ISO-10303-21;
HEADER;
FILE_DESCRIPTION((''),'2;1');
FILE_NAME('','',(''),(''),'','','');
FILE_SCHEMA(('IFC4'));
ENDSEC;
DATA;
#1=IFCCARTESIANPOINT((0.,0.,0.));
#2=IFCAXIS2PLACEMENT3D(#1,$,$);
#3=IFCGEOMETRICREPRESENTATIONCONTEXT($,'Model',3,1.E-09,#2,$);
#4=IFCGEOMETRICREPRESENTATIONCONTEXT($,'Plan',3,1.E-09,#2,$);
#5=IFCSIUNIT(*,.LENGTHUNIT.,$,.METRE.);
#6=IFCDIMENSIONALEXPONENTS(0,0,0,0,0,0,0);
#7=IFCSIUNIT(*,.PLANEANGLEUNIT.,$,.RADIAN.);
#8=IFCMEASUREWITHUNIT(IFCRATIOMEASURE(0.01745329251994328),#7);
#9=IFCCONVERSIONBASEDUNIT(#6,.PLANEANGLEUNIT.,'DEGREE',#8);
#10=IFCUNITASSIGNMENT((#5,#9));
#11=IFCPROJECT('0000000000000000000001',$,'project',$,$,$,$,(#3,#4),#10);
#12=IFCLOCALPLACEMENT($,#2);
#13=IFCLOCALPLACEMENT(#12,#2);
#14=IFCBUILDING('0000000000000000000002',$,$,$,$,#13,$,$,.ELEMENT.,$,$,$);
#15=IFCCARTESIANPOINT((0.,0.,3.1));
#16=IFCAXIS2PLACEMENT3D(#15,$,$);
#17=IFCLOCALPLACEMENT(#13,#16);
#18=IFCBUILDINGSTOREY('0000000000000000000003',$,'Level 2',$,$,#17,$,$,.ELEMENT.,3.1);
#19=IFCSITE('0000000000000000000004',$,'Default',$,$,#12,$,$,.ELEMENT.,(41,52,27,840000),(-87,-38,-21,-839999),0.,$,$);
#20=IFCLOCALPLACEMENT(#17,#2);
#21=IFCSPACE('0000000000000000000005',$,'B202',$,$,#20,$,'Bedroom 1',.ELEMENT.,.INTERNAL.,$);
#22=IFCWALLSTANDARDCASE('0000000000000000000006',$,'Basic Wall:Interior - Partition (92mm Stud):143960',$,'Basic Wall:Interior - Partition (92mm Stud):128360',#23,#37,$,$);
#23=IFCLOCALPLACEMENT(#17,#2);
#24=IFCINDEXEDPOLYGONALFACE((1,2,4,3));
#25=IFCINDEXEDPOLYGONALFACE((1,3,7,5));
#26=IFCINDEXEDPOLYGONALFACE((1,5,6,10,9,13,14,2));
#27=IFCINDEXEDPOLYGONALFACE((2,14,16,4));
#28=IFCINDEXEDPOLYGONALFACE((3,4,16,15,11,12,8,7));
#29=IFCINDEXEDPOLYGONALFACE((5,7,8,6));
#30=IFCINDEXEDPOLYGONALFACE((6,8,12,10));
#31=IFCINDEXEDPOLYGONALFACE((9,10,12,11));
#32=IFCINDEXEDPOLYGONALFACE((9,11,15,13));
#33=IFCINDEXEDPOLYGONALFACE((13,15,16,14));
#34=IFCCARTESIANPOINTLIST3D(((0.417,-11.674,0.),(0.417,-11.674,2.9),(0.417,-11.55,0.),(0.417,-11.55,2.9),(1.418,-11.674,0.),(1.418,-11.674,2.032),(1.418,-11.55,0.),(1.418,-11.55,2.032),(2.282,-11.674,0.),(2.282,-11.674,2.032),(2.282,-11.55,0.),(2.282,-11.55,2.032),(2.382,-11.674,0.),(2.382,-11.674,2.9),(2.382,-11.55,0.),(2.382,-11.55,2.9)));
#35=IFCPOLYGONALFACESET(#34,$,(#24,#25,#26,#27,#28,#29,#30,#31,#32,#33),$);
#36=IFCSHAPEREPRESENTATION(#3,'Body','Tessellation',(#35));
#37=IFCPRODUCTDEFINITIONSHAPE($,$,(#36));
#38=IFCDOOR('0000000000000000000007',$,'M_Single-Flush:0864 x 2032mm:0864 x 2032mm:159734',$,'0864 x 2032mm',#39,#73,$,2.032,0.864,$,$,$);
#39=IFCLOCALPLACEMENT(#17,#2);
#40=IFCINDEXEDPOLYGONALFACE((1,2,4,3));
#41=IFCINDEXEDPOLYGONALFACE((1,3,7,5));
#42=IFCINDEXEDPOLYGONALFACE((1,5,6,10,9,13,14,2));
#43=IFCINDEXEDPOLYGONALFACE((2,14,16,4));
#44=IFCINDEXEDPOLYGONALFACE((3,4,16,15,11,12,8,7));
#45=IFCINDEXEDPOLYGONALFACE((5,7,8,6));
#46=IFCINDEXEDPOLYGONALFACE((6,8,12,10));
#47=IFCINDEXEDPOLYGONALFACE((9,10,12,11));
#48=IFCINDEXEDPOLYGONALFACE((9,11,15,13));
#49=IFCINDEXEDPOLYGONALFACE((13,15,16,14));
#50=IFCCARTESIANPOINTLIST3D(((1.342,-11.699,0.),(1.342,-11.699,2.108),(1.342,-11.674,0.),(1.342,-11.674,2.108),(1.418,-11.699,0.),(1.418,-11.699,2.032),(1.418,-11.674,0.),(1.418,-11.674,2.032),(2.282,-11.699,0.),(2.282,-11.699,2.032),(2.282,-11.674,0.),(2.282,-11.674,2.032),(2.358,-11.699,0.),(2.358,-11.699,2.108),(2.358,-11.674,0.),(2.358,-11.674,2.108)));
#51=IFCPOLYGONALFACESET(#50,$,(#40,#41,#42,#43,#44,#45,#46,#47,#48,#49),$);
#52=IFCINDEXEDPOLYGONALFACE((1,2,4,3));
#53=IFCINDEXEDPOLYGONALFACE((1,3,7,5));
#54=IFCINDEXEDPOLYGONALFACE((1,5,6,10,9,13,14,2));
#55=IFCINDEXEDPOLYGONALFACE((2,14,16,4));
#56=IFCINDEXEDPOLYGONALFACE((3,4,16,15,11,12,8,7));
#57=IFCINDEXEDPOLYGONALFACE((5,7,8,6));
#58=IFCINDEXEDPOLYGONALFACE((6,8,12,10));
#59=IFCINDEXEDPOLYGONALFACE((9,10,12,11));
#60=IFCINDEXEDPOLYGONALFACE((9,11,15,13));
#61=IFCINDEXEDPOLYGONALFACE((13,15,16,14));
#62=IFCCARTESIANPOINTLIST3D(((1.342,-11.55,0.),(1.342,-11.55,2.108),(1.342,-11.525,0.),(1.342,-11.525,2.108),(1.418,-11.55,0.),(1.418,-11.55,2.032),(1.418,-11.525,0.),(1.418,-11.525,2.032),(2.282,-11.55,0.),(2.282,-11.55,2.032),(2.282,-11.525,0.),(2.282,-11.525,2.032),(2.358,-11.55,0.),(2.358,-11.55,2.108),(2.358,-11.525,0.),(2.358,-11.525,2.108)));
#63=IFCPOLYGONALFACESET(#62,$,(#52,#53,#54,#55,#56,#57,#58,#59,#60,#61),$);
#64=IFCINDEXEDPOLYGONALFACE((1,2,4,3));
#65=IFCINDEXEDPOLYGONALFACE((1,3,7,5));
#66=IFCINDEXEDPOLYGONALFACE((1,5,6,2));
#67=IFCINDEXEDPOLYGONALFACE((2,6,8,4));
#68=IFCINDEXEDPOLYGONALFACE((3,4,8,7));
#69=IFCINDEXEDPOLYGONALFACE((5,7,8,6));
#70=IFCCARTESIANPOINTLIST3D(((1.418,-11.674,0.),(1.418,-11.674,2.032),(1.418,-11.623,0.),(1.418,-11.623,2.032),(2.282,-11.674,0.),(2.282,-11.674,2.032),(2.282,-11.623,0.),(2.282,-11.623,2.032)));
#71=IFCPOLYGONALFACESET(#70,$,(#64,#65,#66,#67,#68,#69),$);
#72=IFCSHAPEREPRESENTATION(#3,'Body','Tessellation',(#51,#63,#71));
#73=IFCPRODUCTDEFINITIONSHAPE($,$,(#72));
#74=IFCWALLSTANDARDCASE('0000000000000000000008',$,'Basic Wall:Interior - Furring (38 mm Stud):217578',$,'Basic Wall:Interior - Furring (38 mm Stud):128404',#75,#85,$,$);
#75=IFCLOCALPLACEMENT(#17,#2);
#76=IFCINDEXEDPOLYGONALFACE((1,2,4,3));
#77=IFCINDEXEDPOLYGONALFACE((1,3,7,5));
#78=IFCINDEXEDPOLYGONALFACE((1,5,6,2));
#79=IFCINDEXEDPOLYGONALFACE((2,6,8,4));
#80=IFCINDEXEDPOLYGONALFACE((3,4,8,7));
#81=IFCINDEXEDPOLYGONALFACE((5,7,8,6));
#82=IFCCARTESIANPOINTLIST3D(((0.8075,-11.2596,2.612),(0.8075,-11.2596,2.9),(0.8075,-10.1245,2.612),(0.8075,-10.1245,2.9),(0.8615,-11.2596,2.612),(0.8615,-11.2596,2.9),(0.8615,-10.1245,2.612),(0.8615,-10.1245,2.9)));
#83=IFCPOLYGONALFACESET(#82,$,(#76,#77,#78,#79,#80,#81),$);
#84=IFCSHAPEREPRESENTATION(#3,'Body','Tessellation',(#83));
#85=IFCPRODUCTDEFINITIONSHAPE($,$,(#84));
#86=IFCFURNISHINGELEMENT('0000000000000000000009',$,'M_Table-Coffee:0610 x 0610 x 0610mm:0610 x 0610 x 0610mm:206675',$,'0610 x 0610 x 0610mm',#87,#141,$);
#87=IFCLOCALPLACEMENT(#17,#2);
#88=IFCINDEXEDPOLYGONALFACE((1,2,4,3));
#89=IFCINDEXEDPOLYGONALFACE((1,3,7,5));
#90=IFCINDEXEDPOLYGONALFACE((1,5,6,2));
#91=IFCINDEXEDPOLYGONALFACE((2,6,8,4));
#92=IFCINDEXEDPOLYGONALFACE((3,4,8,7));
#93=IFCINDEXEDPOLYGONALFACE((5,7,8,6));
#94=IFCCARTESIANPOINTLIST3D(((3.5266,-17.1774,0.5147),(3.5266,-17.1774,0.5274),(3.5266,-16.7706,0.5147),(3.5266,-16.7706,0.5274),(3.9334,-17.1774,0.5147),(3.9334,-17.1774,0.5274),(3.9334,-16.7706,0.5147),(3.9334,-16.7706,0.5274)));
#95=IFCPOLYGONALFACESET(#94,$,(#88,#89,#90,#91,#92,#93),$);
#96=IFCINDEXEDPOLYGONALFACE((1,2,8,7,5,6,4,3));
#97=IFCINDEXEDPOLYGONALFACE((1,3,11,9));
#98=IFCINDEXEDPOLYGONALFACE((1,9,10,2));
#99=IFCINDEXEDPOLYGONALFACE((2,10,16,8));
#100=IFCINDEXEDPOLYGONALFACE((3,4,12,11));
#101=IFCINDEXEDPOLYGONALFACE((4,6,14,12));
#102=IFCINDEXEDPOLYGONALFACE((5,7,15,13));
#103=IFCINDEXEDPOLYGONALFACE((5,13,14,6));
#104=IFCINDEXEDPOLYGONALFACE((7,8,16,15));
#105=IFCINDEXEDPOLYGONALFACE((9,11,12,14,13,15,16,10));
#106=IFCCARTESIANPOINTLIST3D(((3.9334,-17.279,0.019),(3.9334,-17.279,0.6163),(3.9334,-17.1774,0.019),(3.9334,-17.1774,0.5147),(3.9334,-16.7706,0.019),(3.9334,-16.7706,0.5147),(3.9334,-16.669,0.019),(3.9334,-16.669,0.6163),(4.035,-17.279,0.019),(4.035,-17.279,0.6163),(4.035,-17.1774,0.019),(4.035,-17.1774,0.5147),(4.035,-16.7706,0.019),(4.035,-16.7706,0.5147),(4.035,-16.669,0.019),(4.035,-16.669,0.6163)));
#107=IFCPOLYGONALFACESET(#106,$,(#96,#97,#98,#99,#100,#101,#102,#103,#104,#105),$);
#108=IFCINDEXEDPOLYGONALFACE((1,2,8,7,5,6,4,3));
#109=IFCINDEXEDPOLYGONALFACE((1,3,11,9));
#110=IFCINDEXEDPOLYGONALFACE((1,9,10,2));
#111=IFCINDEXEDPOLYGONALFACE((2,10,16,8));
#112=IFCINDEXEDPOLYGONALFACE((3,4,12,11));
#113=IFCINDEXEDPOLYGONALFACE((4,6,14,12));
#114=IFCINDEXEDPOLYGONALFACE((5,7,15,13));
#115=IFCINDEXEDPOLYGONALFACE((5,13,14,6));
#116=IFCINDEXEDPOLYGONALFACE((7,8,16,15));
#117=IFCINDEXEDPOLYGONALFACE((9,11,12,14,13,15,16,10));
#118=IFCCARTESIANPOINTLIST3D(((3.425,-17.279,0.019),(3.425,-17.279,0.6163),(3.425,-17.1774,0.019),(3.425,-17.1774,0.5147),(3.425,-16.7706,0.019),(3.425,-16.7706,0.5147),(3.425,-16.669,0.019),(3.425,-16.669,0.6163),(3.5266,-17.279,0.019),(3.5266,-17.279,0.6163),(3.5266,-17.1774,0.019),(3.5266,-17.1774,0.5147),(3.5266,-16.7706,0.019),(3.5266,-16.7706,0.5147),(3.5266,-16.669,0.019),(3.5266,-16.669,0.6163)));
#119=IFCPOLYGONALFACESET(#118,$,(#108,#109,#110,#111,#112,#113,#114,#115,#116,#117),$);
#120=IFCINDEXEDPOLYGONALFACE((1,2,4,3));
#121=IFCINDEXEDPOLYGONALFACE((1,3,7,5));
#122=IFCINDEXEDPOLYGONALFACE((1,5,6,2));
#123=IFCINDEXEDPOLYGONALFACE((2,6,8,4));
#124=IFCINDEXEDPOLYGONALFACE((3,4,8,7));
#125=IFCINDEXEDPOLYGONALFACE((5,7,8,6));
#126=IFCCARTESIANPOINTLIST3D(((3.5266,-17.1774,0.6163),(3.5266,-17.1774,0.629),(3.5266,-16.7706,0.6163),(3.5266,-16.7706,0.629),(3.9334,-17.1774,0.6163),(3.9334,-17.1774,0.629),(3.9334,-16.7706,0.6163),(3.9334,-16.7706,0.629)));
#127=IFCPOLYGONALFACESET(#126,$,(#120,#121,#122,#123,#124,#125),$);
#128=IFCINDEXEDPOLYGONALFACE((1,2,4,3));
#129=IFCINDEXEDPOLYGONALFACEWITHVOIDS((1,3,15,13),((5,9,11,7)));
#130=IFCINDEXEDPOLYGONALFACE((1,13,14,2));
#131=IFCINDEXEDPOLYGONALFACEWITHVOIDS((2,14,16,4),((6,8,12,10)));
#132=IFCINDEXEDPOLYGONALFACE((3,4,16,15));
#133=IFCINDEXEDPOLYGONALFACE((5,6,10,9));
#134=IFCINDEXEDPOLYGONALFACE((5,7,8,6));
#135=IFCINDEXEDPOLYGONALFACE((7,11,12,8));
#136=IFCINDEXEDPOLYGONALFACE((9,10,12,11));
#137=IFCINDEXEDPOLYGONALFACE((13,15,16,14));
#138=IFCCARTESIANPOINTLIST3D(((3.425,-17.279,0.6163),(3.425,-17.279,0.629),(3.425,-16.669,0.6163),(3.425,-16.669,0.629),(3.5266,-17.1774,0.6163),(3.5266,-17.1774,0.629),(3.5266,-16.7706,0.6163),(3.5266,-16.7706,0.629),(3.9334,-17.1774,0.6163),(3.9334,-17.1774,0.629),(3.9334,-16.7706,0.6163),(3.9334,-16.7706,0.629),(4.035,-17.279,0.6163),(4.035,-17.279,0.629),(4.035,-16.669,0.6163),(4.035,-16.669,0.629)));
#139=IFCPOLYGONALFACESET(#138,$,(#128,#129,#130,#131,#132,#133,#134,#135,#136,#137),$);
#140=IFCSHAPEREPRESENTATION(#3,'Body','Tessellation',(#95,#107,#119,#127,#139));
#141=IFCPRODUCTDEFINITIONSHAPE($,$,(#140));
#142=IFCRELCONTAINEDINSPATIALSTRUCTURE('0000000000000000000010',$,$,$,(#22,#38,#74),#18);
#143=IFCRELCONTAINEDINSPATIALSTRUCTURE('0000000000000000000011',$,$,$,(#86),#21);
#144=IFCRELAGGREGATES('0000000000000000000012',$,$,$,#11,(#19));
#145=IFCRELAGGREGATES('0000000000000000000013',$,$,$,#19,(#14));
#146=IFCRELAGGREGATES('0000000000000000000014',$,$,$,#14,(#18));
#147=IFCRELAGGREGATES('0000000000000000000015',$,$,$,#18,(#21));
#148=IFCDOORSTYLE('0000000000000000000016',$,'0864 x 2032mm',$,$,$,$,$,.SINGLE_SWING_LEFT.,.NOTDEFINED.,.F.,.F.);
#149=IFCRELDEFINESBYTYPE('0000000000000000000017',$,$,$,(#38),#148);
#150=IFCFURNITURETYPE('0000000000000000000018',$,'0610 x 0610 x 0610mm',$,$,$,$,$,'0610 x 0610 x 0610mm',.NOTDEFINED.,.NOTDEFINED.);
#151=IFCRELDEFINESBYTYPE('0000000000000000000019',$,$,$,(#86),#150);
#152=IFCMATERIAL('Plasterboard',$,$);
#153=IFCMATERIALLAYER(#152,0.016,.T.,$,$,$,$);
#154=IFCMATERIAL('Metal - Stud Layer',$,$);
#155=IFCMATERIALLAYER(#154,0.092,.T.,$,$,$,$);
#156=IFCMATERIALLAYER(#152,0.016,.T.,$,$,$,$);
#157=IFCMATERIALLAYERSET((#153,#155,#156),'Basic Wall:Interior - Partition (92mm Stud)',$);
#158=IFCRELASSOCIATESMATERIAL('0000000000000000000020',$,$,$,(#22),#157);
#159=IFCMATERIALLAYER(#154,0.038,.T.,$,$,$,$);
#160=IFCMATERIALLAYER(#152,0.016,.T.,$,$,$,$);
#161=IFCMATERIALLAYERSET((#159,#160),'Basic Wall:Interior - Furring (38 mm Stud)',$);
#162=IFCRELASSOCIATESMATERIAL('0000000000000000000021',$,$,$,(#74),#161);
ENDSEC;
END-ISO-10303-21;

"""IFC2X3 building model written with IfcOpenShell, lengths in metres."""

from ifc_helpers import new_model, entity, si_unit, converted_unit, frame, frame_2d, origin, origin_2d_with_axis, place, context, project, spatial, polyline, rectangle, outline, extrude, source, transform, mapped, material, layer, layer_set, layer_usage, type_object, type_shapes, element, fill, save


model = new_model("IFC2X3")

# Units and contexts
model_context = context("Model", 3, precision=1e-09, world=origin())
plan_context = context("Plan", 3, precision=1e-09, world=origin())
ifc_project = project(units=[si_unit("LENGTHUNIT", "METRE"), converted_unit("PLANEANGLEUNIT", "DEGREE", entity("IfcRatioMeasure", 0.01745329251994328), si_unit("PLANEANGLEUNIT", "RADIAN"), dimensions=[0, 0, 0, 0, 0, 0, 0])], contexts=[model_context, plan_context])

# Site, building, storey
site_placement = place(None, origin())
site = spatial("IfcSite", under=ifc_project, at=site_placement, Name="Default", CompositionType="ELEMENT", RefLatitude=(41, 52, 27, 840000), RefLongitude=(-87, -38, -21, -839999), RefElevation=0.0)
building_placement = place(site_placement, origin())
building = spatial("IfcBuilding", under=site, at=building_placement, CompositionType="ELEMENT")
storey_placement = place(building_placement, frame((0.0, 0.0, 3.1)))
storey = spatial("IfcBuildingStorey", under=building, at=storey_placement, Name="Level 2", CompositionType="ELEMENT", Elevation=3.1)

# Shared definitions
ifc_material_1 = material(Name="Metal - Stud Layer")
ifc_layer_1 = layer(ifc_material_1, 0.038, ventilated=True)
ifc_material_2 = material(Name="Plasterboard")
ifc_layer_2 = layer(ifc_material_2, 0.016, ventilated=True)
ifc_layer_set_1 = layer_set([ifc_layer_1, ifc_layer_2], Name="Basic Wall:Interior - Furring (38 mm Stud)")
ifc_layer_usage_1 = layer_usage(ifc_layer_set_1, "AXIS2", "NEGATIVE", 0.027)

# Wall, opening, door
ifc_layer_3 = layer(ifc_material_2, 0.016, ventilated=True)
ifc_layer_4 = layer(ifc_material_1, 0.092, ventilated=True)
ifc_layer_5 = layer(ifc_material_2, 0.016, ventilated=True)
ifc_layer_set_2 = layer_set([ifc_layer_3, ifc_layer_4, ifc_layer_5], Name="Basic Wall:Interior - Partition (92mm Stud)")
ifc_layer_usage_2 = layer_usage(ifc_layer_set_2, "AXIS2", "NEGATIVE", 0.062)
wall_1_placement = place(storey_placement, frame((2.382, -11.612, 0.0), z_axis=(0.0, 0.0, 1.0), x_axis=(-1.0, 0.0, 0.0)))
wall_1 = element("IfcWallStandardCase", 1, at=wall_1_placement, inside=storey, material=ifc_layer_usage_2, Name="Basic Wall:Interior - Partition (92mm Stud):143960", ObjectType="Basic Wall:Interior - Partition (92mm Stud):128360", context=model_context, shape_type="SweptSolid", body=[
    extrude(rectangle(XDim=1.965, YDim=0.124, at=frame_2d((0.9825, 0.0), x_axis=(-1.0, 0.0))), origin(), (0.0, 0.0, 1.0), 2.9),
])
opening_1_placement = place(wall_1_placement, frame((0.1, -0.062, 0.0)))
opening_1 = element("IfcOpeningElement", 2, at=opening_1_placement, cuts=wall_1, ObjectType="Opening", context=model_context, shape_type="SweptSolid", body=[
    extrude(rectangle(XDim=0.864, YDim=2.032, at=frame_2d((1.016, 0.432), x_axis=(0.0, -1.0))), frame((0.0, 0.0, 0.0), z_axis=(0.0, 1.0, 0.0), x_axis=(0.0, 0.0, 1.0)), (0.0, 0.0, 1.0), 0.124),
])
door_style = type_object("IfcDoorStyle", Name="0864 x 2032mm", ConstructionType="NOTDEFINED", OperationType="SINGLE_SWING_LEFT", ParameterTakesPrecedence=False, Sizeable=False)
shared_shape_1 = source(origin(), model_context, "Body", "SweptSolid", [
    extrude(outline(polyline([(-0.508, -1.073), (0.508, -1.073), (0.508, 1.035), (0.432, 1.035), (0.432, -0.997), (-0.432, -0.997), (-0.432, 1.035), (-0.508, 1.035), (-0.508, -1.073)])), frame((0.432, 0.149, 1.035), z_axis=(0.0, -1.0, 0.0), x_axis=(-1.0, 0.0, 0.0)), (0.0, 0.0, 1.0), 0.025),
    extrude(outline(polyline([(-1.073, -0.508), (1.035, -0.508), (1.035, -0.432), (-0.997, -0.432), (-0.997, 0.432), (1.035, 0.432), (1.035, 0.508), (-1.073, 0.508), (-1.073, -0.508)])), frame((0.432, 0.0, 1.035), z_axis=(0.0, -1.0, 0.0), x_axis=(0.0, 0.0, -1.0)), (0.0, 0.0, 1.0), 0.025),
    extrude(rectangle(XDim=0.864, YDim=0.051, at=origin_2d_with_axis()), frame((0.432, 0.0985, 0.0)), (0.0, 0.0, 1.0), 2.032),
])
type_shapes(door_style, [shared_shape_1])
door_placement = place(opening_1_placement, origin())
door = element("IfcDoor", 3, at=door_placement, inside=storey, type_object=door_style, Name="M_Single-Flush:0864 x 2032mm:0864 x 2032mm:159734", ObjectType="0864 x 2032mm", OverallHeight=2.032, OverallWidth=0.864, context=model_context, shape_type="MappedRepresentation", body=[
    mapped(shared_shape_1, transform((0.0, 0.0, 0.0), scale=1.0)),
])
fill(opening_1, door)

# Wall
wall_2_placement = place(storey_placement, frame((0.8345, -11.2596, 2.612), z_axis=(0.0, 0.0, 1.0), x_axis=(0.0, 1.0, 0.0)))
element("IfcWallStandardCase", 4, at=wall_2_placement, inside=storey, material=ifc_layer_usage_1, Name="Basic Wall:Interior - Furring (38 mm Stud):217578", ObjectType="Basic Wall:Interior - Furring (38 mm Stud):128404", context=model_context, shape_type="SweptSolid", body=[
    extrude(rectangle(XDim=1.1351, YDim=0.054, at=frame_2d((0.5675, 0.0), x_axis=(-1.0, 0.0))), origin(), (0.0, 0.0, 1.0), 0.288),
])

# Shared definitions
space_placement = place(storey_placement, origin())
space = spatial("IfcSpace", under=storey, at=space_placement, Name="B202", LongName="Bedroom 1", CompositionType="ELEMENT", InteriorOrExteriorSpace="INTERNAL")

# Furnishing element
furniture_type = type_object("IfcFurnitureType", Name="0610 x 0610 x 0610mm", ElementType="0610 x 0610 x 0610mm", AssemblyPlace="NOTDEFINED")
shared_shape_2 = source(origin(), model_context, "Body", "SweptSolid", [
    extrude(rectangle(XDim=0.4068, YDim=0.4068, at=origin_2d_with_axis()), frame((0.0183, 0.0952, 0.4957), z_axis=(0.0, 0.0, 1.0), x_axis=(-1.0, 0.0, 0.0)), (0.0, 0.0, 1.0), 0.0127),
    extrude(outline(polyline([(-0.2732, -0.305), (0.324, -0.305), (0.324, 0.305), (-0.2732, 0.305), (-0.2732, 0.2034), (0.2225, 0.2034), (0.2225, -0.2034), (-0.2732, -0.2034), (-0.2732, -0.305)])), frame((0.2217, 0.0952, 0.2732), z_axis=(1.0, 0.0, 0.0), x_axis=(0.0, 0.0, 1.0)), (0.0, 0.0, 1.0), 0.1016),
    extrude(outline(polyline([(-0.305, -0.3241), (0.305, -0.3241), (0.305, 0.2733), (0.2034, 0.2733), (0.2034, -0.2224), (-0.2034, -0.2224), (-0.2034, 0.2733), (-0.305, 0.2733), (-0.305, -0.3241)])), frame((-0.2867, 0.0952, 0.2733), z_axis=(1.0, 0.0, 0.0), x_axis=(0.0, -1.0, 0.0)), (0.0, 0.0, 1.0), 0.1016),
    extrude(rectangle(XDim=0.4068, YDim=0.4068, at=origin_2d_with_axis()), frame((0.0183, 0.0952, 0.5973), z_axis=(0.0, 0.0, 1.0), x_axis=(-1.0, 0.0, 0.0)), (0.0, 0.0, 1.0), 0.0127),
    extrude(outline(polyline([(-0.305, -0.305), (0.305, -0.305), (0.305, 0.305), (-0.305, 0.305), (-0.305, -0.305)]), holes=[polyline([(-0.2034, -0.2034), (-0.2034, 0.2034), (0.2034, 0.2034), (0.2034, -0.2034), (-0.2034, -0.2034)])]), frame((0.0183, 0.0952, 0.5973), z_axis=(0.0, 0.0, 1.0), x_axis=(-1.0, 0.0, 0.0)), (0.0, 0.0, 1.0), 0.0127),
])
type_shapes(furniture_type, [shared_shape_2])
furnishing_placement = place(space_placement, frame((3.7117, -17.0692, 0.019)))
element("IfcFurnishingElement", 5, at=furnishing_placement, inside=space, type_object=furniture_type, Name="M_Table-Coffee:0610 x 0610 x 0610mm:0610 x 0610 x 0610mm:206675", ObjectType="0610 x 0610 x 0610mm", context=model_context, shape_type="MappedRepresentation", body=[
    mapped(shared_shape_2, transform((0.0, 0.0, 0.0), scale=1.0)),
])

save(model, "model.ifc")
